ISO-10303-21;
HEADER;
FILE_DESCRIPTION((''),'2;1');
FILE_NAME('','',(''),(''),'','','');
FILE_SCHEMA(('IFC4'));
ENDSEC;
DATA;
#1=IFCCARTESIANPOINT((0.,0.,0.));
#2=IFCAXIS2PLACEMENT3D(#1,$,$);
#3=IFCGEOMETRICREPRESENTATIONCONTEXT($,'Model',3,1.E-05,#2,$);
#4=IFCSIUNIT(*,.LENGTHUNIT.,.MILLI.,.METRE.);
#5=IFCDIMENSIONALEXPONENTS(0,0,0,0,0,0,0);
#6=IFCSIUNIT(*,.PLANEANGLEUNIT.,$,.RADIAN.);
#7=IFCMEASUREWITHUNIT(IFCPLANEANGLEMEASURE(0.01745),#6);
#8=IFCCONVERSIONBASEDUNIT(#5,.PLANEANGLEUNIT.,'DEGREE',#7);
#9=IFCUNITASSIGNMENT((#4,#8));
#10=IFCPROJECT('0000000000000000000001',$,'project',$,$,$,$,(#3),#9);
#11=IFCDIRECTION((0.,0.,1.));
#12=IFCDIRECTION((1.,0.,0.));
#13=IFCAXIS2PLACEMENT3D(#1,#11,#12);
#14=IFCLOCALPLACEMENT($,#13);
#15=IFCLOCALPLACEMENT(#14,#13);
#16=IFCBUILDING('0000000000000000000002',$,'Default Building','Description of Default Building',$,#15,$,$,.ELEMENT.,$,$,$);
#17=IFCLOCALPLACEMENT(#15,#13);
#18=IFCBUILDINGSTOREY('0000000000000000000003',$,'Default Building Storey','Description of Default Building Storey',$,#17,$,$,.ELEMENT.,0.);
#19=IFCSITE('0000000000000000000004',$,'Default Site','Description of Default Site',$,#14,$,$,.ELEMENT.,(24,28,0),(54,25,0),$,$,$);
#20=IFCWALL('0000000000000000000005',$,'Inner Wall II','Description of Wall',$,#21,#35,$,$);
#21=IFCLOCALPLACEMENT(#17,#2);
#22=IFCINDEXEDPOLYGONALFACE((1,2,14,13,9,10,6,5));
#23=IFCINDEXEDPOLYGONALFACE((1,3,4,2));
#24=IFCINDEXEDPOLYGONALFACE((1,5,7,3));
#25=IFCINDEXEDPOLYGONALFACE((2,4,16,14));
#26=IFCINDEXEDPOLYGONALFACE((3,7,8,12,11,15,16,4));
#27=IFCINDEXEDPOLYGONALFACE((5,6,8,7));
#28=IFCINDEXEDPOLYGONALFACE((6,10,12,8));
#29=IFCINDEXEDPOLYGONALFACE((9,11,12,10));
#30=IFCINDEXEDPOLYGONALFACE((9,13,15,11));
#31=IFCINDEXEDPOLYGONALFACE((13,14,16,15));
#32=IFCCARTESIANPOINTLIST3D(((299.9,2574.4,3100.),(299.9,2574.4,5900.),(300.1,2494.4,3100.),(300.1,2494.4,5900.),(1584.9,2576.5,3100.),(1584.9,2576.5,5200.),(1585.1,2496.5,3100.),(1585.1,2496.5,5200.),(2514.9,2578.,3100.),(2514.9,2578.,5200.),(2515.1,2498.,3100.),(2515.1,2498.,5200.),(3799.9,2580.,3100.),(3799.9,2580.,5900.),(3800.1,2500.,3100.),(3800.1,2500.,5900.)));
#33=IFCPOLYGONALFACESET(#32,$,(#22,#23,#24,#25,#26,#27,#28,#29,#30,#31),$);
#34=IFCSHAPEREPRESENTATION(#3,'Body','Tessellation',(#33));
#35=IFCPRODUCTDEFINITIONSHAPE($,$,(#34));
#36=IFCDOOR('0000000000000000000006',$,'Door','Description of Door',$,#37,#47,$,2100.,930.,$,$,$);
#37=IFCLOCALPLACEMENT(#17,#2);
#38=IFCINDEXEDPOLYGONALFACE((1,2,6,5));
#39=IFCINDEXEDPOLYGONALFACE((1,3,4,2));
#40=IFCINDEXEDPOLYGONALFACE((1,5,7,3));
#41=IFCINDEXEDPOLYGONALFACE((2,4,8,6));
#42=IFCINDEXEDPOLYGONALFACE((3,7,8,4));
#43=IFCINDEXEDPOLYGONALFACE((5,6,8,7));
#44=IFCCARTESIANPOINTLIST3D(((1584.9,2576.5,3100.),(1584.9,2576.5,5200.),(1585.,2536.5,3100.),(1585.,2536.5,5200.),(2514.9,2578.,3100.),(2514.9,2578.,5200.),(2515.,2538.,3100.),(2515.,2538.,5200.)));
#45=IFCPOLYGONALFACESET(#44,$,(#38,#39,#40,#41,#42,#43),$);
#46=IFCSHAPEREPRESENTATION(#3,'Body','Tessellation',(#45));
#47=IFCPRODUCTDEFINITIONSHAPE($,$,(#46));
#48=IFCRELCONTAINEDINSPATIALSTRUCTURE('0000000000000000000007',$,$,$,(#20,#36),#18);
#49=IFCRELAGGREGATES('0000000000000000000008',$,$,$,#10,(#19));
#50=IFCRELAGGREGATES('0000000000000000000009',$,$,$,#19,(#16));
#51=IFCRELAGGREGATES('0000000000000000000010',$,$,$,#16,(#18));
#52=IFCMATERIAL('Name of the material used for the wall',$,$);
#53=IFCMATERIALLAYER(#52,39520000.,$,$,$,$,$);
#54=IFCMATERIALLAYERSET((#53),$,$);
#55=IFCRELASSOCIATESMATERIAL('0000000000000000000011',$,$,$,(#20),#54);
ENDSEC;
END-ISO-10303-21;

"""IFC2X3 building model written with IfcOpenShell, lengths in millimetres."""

from ifc_helpers import new_model, entity, si_unit, converted_unit, frame, origin, origin_with_axes, place, context, project, spatial, polyline, outline, extrude, material, layer, layer_set, layer_usage, element, fill, save


model = new_model("IFC2X3")

# Units and contexts
model_context = context("Model", 3, precision=1e-05, world=origin())
ifc_project = project(units=[si_unit("LENGTHUNIT", "METRE", prefix="MILLI"), converted_unit("PLANEANGLEUNIT", "DEGREE", entity("IfcPlaneAngleMeasure", 0.01745), si_unit("PLANEANGLEUNIT", "RADIAN"), dimensions=[0, 0, 0, 0, 0, 0, 0])], contexts=[model_context])

# Site, building, storey
site_placement = place(None, origin_with_axes())
site = spatial("IfcSite", under=ifc_project, at=site_placement, Name="Default Site", Description="Description of Default Site", CompositionType="ELEMENT", RefLatitude=(24, 28, 0), RefLongitude=(54, 25, 0))
building_placement = place(site_placement, origin_with_axes())
building = spatial("IfcBuilding", under=site, at=building_placement, Name="Default Building", Description="Description of Default Building", CompositionType="ELEMENT")
storey_placement = place(building_placement, origin_with_axes())
storey = spatial("IfcBuildingStorey", under=building, at=storey_placement, Name="Default Building Storey", Description="Description of Default Building Storey", CompositionType="ELEMENT", Elevation=0.0)

# Wall, opening, door
ifc_material_1 = material(Name="Name of the material used for the wall")
ifc_layer_1 = layer(ifc_material_1, 39520000.0)
ifc_layer_set_1 = layer_set([ifc_layer_1])
ifc_layer_usage_1 = layer_usage(ifc_layer_set_1, "AXIS2", "POSITIVE", -19760000.0)
wall_1_placement = place(storey_placement, frame((3800.0, 2540.0, 3100.0), z_axis=(0.0, 0.0, 1.0), x_axis=(-1.0, -0.001593, 0.0)))
wall_1 = element("IfcWall", 1, at=wall_1_placement, inside=storey, material=ifc_layer_usage_1, Name="Inner Wall II", Description="Description of Wall", context=model_context, shape_type="SweptSolid", body=[
    extrude(outline(polyline([(0.0, -40.0), (0.0, 40.0), (3500.0, 40.0), (3500.0, -40.0), (0.0, -40.0)])), origin_with_axes(), (0.0, 0.0, 1.0), 2800.0),
])
opening_1_placement = place(wall_1_placement, frame((1285.0, -40.0, 0.0), z_axis=(0.0, 0.0, 1.0), x_axis=(1.0, 0.0, 0.0)))
opening_1 = element("IfcOpeningElement", 2, at=opening_1_placement, cuts=wall_1, context=model_context, shape_type="SweptSolid", body=[
    extrude(outline(polyline([(0.0, 0.0), (0.0, 80.0), (930.0, 80.0), (930.0, 0.0), (0.0, 0.0)])), origin_with_axes(), (0.0, 0.0, 1.0), 2100.0),
])
door_1_placement = place(opening_1_placement, origin_with_axes())
door_1 = element("IfcDoor", 3, at=door_1_placement, inside=storey, Name="Door", Description="Description of Door", OverallHeight=2100.0, OverallWidth=930.0, context=model_context, shape_type="SweptSolid", body=[
    extrude(outline(polyline([(0.0, 0.0), (0.0, 40.0), (930.0, 40.0), (930.0, 0.0), (0.0, 0.0)])), origin_with_axes(), (0.0, 0.0, 1.0), 2100.0),
])
fill(opening_1, door_1)

save(model, "model.ifc")
